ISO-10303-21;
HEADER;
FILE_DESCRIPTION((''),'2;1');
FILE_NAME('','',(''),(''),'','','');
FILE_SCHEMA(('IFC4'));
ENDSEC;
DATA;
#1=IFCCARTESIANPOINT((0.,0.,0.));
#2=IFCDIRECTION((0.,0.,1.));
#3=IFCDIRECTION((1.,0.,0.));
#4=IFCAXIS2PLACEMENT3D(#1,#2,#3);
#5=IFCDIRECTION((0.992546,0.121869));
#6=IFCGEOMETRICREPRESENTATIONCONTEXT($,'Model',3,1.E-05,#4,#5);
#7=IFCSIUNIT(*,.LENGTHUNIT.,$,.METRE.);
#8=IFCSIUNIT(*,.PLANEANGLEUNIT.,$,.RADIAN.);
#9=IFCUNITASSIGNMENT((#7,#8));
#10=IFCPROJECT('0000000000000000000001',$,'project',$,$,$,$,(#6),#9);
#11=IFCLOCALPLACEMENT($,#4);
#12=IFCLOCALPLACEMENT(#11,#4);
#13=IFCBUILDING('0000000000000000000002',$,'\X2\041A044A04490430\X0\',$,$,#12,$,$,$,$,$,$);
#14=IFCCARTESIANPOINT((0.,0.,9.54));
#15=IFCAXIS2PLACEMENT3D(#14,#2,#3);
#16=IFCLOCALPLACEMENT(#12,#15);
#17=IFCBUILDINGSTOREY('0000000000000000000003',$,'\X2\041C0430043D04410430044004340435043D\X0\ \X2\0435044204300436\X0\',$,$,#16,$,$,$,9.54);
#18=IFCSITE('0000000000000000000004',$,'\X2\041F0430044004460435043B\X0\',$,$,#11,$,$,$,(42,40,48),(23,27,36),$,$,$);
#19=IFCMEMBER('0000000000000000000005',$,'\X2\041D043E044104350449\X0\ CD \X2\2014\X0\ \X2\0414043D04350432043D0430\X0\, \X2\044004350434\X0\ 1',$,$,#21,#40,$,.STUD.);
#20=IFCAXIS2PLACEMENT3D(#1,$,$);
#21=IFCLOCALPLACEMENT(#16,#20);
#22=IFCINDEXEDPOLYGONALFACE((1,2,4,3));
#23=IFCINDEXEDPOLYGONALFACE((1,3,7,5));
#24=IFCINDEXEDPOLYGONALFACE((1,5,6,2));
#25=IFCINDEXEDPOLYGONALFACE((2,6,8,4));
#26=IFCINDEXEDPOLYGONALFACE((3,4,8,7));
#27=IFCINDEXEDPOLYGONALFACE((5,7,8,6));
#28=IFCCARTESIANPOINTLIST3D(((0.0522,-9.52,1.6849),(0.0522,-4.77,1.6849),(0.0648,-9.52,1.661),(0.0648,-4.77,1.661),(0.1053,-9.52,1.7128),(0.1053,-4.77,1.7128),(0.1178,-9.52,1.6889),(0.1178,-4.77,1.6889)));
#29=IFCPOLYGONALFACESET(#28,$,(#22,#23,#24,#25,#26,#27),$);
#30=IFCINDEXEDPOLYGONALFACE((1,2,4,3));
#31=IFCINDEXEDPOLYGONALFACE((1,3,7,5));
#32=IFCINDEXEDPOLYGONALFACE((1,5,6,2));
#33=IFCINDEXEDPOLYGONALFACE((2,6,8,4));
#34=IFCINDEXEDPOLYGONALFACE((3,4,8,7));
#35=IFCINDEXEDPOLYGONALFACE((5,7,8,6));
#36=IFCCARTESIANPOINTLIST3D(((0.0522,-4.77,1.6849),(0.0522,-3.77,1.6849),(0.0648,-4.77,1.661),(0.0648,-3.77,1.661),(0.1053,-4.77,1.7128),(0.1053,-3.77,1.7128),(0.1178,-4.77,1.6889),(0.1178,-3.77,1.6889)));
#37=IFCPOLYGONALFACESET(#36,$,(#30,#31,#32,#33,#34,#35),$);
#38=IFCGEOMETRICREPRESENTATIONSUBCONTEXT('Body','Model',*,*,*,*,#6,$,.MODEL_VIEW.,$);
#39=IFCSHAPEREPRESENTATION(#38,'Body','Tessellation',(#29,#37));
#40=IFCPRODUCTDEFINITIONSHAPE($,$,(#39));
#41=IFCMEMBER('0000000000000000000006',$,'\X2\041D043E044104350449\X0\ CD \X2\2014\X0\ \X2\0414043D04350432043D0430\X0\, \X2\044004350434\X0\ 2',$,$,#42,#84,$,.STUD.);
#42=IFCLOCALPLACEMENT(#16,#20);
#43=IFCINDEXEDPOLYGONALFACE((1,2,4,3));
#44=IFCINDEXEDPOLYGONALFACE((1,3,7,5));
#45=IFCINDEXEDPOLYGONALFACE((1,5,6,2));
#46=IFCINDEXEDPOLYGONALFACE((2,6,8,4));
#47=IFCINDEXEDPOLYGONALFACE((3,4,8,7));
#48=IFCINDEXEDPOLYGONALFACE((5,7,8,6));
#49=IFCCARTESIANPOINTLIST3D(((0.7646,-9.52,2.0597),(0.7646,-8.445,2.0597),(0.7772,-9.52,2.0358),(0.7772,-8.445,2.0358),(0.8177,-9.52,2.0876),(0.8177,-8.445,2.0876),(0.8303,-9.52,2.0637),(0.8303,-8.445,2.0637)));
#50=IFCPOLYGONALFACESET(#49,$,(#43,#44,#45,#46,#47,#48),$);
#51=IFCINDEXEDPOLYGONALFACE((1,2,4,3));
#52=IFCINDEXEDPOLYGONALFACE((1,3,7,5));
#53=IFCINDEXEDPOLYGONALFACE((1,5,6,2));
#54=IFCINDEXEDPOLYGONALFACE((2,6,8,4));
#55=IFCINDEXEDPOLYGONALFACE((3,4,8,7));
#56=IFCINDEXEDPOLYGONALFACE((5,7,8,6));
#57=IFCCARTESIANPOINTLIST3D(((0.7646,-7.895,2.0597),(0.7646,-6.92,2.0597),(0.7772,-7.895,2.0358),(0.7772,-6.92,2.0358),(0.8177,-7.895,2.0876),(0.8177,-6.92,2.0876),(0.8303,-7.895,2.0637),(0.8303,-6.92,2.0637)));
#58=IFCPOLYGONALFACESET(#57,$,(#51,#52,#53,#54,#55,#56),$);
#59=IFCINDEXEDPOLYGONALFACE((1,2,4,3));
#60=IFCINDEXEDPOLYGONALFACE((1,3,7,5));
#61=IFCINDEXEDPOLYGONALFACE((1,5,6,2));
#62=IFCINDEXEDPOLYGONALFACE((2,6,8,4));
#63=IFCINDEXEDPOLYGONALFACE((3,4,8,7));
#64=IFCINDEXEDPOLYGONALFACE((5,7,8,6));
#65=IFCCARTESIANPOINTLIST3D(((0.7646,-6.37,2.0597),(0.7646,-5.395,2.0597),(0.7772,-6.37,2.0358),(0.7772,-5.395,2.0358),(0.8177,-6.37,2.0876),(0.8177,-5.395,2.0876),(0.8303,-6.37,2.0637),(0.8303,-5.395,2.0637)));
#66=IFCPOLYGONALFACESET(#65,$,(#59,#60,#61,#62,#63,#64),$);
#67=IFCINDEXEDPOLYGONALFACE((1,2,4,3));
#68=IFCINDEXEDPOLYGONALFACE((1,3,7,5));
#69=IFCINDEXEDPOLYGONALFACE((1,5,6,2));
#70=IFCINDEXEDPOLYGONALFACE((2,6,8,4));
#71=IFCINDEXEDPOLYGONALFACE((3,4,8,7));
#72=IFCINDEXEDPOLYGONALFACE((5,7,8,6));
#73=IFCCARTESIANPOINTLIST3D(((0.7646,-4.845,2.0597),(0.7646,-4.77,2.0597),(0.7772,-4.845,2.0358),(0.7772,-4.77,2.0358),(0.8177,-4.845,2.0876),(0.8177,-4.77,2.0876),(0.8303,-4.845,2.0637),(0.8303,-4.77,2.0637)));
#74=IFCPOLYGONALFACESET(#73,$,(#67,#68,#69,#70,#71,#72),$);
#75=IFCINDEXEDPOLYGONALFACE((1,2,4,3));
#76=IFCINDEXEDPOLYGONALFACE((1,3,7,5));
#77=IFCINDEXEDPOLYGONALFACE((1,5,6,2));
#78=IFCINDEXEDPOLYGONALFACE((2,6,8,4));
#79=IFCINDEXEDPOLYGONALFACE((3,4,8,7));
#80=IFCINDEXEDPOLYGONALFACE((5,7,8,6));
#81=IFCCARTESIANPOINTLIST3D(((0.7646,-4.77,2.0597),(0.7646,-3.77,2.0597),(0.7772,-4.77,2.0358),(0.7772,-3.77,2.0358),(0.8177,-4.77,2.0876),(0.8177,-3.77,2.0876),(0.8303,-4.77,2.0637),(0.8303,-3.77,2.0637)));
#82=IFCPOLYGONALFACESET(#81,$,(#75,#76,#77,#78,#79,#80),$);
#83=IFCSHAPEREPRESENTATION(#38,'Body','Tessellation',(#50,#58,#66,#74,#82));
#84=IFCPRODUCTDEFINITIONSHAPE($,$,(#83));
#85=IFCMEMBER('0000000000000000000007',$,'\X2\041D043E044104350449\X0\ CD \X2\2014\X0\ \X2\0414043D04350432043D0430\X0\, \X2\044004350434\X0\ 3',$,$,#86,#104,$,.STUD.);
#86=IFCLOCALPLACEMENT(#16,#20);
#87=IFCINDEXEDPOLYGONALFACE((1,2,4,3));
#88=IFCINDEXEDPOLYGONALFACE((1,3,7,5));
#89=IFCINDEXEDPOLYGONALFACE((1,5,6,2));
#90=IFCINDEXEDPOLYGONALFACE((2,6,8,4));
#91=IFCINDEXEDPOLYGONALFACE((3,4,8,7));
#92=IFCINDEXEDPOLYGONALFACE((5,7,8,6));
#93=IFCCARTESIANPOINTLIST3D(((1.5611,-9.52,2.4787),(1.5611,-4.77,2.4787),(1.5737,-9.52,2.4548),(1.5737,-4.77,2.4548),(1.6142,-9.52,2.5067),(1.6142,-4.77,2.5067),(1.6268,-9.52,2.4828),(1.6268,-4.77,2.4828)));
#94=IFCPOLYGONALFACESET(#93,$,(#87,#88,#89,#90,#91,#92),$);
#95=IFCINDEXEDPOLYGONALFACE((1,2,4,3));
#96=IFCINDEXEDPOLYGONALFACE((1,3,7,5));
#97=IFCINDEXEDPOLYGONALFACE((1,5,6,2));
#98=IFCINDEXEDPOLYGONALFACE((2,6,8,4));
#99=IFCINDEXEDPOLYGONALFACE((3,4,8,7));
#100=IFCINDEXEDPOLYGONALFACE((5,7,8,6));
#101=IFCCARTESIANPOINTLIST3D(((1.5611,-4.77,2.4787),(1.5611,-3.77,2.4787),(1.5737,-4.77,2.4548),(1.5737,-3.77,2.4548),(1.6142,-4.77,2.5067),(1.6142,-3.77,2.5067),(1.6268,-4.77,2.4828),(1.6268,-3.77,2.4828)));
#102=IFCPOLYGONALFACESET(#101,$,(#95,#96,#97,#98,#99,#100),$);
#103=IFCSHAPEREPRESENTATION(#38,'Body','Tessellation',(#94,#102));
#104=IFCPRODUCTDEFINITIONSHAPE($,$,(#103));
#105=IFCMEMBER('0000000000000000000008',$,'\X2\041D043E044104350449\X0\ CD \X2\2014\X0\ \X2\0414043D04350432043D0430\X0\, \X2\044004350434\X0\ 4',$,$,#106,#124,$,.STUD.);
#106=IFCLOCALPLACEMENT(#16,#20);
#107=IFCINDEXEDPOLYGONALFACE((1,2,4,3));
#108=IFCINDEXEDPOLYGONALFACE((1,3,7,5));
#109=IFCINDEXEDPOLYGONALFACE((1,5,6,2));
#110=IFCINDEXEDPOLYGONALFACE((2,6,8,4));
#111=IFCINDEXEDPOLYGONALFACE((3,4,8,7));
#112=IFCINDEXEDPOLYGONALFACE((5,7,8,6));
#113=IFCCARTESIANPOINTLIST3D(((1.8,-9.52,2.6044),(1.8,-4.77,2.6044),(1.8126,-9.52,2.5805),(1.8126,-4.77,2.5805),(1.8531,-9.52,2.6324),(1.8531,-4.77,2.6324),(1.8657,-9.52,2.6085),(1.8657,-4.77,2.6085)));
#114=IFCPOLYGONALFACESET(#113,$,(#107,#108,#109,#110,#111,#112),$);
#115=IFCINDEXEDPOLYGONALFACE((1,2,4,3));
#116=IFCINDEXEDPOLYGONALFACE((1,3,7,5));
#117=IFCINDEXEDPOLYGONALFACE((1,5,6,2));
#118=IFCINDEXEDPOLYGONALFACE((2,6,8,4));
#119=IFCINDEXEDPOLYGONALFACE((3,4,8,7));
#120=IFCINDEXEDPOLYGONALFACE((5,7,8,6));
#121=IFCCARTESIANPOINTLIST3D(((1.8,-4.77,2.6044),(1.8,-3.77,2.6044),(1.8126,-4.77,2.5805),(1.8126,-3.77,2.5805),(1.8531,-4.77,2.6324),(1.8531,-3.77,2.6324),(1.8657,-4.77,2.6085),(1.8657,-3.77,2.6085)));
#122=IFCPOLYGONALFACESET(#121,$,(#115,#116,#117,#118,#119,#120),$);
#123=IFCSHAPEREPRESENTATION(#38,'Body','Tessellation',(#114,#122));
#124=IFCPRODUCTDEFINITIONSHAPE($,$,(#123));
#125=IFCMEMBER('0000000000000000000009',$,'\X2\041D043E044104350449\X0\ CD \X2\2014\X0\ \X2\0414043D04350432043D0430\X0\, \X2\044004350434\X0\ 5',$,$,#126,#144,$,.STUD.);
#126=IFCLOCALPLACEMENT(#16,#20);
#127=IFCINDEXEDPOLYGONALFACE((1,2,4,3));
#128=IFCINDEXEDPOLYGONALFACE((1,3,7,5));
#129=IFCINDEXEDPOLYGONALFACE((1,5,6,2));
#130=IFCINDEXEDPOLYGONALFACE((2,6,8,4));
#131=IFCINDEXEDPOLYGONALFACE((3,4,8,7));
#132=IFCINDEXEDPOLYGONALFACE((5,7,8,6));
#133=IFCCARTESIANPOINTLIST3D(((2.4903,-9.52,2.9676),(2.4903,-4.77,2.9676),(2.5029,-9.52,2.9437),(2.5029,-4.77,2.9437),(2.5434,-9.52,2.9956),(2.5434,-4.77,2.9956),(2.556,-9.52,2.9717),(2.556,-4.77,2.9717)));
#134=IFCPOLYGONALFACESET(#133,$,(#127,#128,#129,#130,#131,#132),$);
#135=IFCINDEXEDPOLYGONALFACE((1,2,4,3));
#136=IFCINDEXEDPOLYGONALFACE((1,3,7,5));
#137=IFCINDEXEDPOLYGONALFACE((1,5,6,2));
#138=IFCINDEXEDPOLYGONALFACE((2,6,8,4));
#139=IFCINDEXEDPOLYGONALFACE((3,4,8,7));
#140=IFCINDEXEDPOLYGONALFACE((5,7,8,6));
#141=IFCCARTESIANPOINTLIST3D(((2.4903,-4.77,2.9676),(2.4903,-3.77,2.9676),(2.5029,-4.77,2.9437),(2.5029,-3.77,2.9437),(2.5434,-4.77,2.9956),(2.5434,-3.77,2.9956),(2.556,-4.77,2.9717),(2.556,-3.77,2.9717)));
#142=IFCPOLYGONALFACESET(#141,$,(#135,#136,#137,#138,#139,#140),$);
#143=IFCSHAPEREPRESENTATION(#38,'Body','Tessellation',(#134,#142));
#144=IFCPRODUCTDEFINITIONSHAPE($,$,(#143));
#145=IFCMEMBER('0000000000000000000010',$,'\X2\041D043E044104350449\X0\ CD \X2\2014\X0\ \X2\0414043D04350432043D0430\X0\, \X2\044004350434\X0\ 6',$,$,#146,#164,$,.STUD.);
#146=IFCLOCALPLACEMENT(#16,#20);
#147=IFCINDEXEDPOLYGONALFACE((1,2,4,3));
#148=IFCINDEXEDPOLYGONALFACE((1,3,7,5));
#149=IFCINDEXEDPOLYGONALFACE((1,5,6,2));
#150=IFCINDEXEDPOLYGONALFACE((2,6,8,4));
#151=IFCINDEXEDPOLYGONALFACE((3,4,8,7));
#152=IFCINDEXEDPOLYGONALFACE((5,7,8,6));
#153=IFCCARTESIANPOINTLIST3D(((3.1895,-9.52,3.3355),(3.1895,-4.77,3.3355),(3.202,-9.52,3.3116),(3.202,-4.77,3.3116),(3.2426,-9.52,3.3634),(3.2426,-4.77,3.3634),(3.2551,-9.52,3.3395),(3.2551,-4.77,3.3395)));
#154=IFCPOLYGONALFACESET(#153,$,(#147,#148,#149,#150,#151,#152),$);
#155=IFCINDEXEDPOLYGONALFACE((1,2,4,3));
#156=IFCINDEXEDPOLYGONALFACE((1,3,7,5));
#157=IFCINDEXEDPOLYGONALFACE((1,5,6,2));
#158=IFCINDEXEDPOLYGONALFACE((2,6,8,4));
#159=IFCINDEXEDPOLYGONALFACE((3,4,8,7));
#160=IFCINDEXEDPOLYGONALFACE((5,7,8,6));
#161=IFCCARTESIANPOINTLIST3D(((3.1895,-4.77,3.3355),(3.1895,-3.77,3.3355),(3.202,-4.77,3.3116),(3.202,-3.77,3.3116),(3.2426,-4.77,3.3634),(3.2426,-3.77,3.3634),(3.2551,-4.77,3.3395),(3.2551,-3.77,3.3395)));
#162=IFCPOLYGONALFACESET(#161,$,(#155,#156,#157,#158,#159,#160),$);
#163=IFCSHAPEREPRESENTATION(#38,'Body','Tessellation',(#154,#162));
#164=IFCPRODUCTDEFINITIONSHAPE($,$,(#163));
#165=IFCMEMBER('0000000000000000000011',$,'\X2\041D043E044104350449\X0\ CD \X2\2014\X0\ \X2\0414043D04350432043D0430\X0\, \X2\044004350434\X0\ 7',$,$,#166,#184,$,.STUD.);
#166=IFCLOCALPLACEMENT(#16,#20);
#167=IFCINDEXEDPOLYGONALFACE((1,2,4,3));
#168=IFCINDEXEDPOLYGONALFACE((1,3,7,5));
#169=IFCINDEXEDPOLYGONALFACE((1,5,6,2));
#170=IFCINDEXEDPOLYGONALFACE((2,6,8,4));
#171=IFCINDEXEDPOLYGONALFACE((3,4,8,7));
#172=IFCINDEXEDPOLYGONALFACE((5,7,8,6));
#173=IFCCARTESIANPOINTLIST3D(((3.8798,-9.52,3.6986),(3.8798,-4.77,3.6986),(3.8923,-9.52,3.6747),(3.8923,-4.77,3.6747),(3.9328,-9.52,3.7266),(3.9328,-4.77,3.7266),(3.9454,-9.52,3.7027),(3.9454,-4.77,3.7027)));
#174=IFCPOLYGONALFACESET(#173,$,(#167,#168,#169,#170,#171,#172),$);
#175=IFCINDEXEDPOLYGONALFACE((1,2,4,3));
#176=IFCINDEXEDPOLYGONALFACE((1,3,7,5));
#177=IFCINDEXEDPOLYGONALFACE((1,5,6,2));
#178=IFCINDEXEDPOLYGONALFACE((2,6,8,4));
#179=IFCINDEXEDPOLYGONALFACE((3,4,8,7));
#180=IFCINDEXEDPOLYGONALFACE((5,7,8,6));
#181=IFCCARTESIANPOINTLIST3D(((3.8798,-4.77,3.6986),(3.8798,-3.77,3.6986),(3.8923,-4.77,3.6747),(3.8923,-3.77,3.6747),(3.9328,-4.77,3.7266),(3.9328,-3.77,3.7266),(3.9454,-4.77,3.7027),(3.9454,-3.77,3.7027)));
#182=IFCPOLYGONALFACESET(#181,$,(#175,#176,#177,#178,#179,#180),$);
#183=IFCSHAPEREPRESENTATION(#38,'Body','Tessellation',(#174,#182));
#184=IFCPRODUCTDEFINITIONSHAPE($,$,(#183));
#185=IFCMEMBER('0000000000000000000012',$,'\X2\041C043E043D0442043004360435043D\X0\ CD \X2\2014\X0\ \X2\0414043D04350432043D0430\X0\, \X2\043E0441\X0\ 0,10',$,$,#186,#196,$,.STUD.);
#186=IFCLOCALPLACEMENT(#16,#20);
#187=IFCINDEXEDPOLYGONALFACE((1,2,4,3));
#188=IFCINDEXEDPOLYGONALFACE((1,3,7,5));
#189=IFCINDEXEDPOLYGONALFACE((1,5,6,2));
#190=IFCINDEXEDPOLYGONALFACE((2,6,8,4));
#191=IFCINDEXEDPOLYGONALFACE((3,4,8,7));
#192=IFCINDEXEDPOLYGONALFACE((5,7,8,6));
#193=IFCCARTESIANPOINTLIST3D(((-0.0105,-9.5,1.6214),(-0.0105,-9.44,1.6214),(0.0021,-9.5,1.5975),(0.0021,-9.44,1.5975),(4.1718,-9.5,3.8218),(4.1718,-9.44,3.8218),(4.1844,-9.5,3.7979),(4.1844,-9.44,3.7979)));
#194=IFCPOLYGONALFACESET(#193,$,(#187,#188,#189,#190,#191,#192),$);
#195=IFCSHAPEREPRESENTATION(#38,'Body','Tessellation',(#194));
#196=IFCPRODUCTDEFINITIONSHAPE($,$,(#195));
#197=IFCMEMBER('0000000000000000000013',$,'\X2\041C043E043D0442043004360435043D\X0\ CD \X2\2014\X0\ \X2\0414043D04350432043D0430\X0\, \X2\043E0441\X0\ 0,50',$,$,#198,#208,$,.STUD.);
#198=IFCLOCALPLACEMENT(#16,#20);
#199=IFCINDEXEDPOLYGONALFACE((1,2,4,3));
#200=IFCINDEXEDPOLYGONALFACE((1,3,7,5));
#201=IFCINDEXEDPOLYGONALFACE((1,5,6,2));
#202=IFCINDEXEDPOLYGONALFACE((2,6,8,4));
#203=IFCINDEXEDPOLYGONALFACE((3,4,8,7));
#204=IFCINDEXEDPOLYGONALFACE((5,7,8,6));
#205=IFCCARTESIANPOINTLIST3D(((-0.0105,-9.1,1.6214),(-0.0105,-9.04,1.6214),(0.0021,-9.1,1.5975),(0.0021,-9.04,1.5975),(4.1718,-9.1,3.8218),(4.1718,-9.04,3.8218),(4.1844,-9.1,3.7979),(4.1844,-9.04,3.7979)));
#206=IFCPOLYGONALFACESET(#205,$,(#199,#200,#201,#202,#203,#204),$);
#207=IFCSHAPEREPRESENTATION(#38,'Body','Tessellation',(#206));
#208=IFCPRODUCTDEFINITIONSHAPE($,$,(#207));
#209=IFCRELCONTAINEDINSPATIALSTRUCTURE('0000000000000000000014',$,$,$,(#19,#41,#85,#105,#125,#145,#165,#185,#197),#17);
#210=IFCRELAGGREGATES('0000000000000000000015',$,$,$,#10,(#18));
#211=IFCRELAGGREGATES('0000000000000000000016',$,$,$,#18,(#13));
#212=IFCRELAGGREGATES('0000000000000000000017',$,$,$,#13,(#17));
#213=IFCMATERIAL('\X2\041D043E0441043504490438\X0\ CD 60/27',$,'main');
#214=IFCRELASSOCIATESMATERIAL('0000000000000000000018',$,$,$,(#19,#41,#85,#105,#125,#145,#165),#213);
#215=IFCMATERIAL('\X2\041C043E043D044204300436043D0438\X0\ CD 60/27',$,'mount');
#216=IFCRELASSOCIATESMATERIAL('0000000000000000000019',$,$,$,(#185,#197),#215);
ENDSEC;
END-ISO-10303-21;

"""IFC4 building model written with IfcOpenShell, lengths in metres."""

from ifc_helpers import new_model, si_unit, direction, frame, origin_with_axes, place, context, subcontext, project, spatial, polyline, outline, extrude, material, element, save


model = new_model("IFC4")

# Units and contexts
model_context = context("Model", 3, precision=1e-05, world=origin_with_axes(), true_north=direction((0.992546, 0.121869)))
body_context = subcontext(model_context, "Body", "Model", "MODEL_VIEW")
ifc_project = project(units=[si_unit("LENGTHUNIT", "METRE"), si_unit("PLANEANGLEUNIT", "RADIAN")], contexts=[model_context])

# Site, building, storey
site_placement = place(None, origin_with_axes())
site = spatial("IfcSite", under=ifc_project, at=site_placement, Name="Парцел", RefLatitude=(42, 40, 48), RefLongitude=(23, 27, 36))
building_placement = place(site_placement, origin_with_axes())
building = spatial("IfcBuilding", under=site, at=building_placement, Name="Къща")
storey_placement = place(building_placement, frame((0.0, 0.0, 9.54), z_axis=(0.0, 0.0, 1.0), x_axis=(1.0, 0.0, 0.0)))
storey = spatial("IfcBuildingStorey", under=building, at=storey_placement, Name="Мансарден етаж", Elevation=9.54)

# Members
ifc_material_1 = material(Name="Носещи CD 60/27", Category="main")
member_1_placement = place(storey_placement, origin_with_axes())
element("IfcMember", 1, at=member_1_placement, inside=storey, material=ifc_material_1, Name="Носещ CD — Дневна, ред 1", PredefinedType="STUD", context=body_context, shape_type="SweptSolid", body=[
    extrude(outline(polyline([(0.0648, -1.661), (0.1178, -1.6889), (0.1053, -1.7128), (0.0522, -1.6849), (0.0648, -1.661)])), frame((0.0, -9.52, 0.0), z_axis=(0.0, 1.0, 0.0), x_axis=(1.0, 0.0, 0.0)), (0.0, 0.0, 1.0), 4.75),
    extrude(outline(polyline([(0.0648, -1.661), (0.1178, -1.6889), (0.1053, -1.7128), (0.0522, -1.6849), (0.0648, -1.661)])), frame((0.0, -4.77, 0.0), z_axis=(0.0, 1.0, 0.0), x_axis=(1.0, 0.0, 0.0)), (0.0, 0.0, 1.0), 1.0),
])
member_2_placement = place(storey_placement, origin_with_axes())
element("IfcMember", 2, at=member_2_placement, inside=storey, material=ifc_material_1, Name="Носещ CD — Дневна, ред 2", PredefinedType="STUD", context=body_context, shape_type="SweptSolid", body=[
    extrude(outline(polyline([(0.7772, -2.0358), (0.8303, -2.0637), (0.8177, -2.0876), (0.7646, -2.0597), (0.7772, -2.0358)])), frame((0.0, -9.52, 0.0), z_axis=(0.0, 1.0, 0.0), x_axis=(1.0, 0.0, 0.0)), (0.0, 0.0, 1.0), 1.075),
    extrude(outline(polyline([(0.7772, -2.0358), (0.8303, -2.0637), (0.8177, -2.0876), (0.7646, -2.0597), (0.7772, -2.0358)])), frame((0.0, -7.895, 0.0), z_axis=(0.0, 1.0, 0.0), x_axis=(1.0, 0.0, 0.0)), (0.0, 0.0, 1.0), 0.975),
    extrude(outline(polyline([(0.7772, -2.0358), (0.8303, -2.0637), (0.8177, -2.0876), (0.7646, -2.0597), (0.7772, -2.0358)])), frame((0.0, -6.37, 0.0), z_axis=(0.0, 1.0, 0.0), x_axis=(1.0, 0.0, 0.0)), (0.0, 0.0, 1.0), 0.975),
    extrude(outline(polyline([(0.7772, -2.0358), (0.8303, -2.0637), (0.8177, -2.0876), (0.7646, -2.0597), (0.7772, -2.0358)])), frame((0.0, -4.845, 0.0), z_axis=(0.0, 1.0, 0.0), x_axis=(1.0, 0.0, 0.0)), (0.0, 0.0, 1.0), 0.075),
    extrude(outline(polyline([(0.7772, -2.0358), (0.8303, -2.0637), (0.8177, -2.0876), (0.7646, -2.0597), (0.7772, -2.0358)])), frame((0.0, -4.77, 0.0), z_axis=(0.0, 1.0, 0.0), x_axis=(1.0, 0.0, 0.0)), (0.0, 0.0, 1.0), 1.0),
])
member_3_placement = place(storey_placement, origin_with_axes())
element("IfcMember", 3, at=member_3_placement, inside=storey, material=ifc_material_1, Name="Носещ CD — Дневна, ред 3", PredefinedType="STUD", context=body_context, shape_type="SweptSolid", body=[
    extrude(outline(polyline([(1.5737, -2.4548), (1.6268, -2.4828), (1.6142, -2.5067), (1.5611, -2.4787), (1.5737, -2.4548)])), frame((0.0, -9.52, 0.0), z_axis=(0.0, 1.0, 0.0), x_axis=(1.0, 0.0, 0.0)), (0.0, 0.0, 1.0), 4.75),
    extrude(outline(polyline([(1.5737, -2.4548), (1.6268, -2.4828), (1.6142, -2.5067), (1.5611, -2.4787), (1.5737, -2.4548)])), frame((0.0, -4.77, 0.0), z_axis=(0.0, 1.0, 0.0), x_axis=(1.0, 0.0, 0.0)), (0.0, 0.0, 1.0), 1.0),
])
member_4_placement = place(storey_placement, origin_with_axes())
element("IfcMember", 4, at=member_4_placement, inside=storey, material=ifc_material_1, Name="Носещ CD — Дневна, ред 4", PredefinedType="STUD", context=body_context, shape_type="SweptSolid", body=[
    extrude(outline(polyline([(1.8126, -2.5805), (1.8657, -2.6085), (1.8531, -2.6324), (1.8, -2.6044), (1.8126, -2.5805)])), frame((0.0, -9.52, 0.0), z_axis=(0.0, 1.0, 0.0), x_axis=(1.0, 0.0, 0.0)), (0.0, 0.0, 1.0), 4.75),
    extrude(outline(polyline([(1.8126, -2.5805), (1.8657, -2.6085), (1.8531, -2.6324), (1.8, -2.6044), (1.8126, -2.5805)])), frame((0.0, -4.77, 0.0), z_axis=(0.0, 1.0, 0.0), x_axis=(1.0, 0.0, 0.0)), (0.0, 0.0, 1.0), 1.0),
])
member_5_placement = place(storey_placement, origin_with_axes())
element("IfcMember", 5, at=member_5_placement, inside=storey, material=ifc_material_1, Name="Носещ CD — Дневна, ред 5", PredefinedType="STUD", context=body_context, shape_type="SweptSolid", body=[
    extrude(outline(polyline([(2.5029, -2.9437), (2.556, -2.9717), (2.5434, -2.9956), (2.4903, -2.9676), (2.5029, -2.9437)])), frame((0.0, -9.52, 0.0), z_axis=(0.0, 1.0, 0.0), x_axis=(1.0, 0.0, 0.0)), (0.0, 0.0, 1.0), 4.75),
    extrude(outline(polyline([(2.5029, -2.9437), (2.556, -2.9717), (2.5434, -2.9956), (2.4903, -2.9676), (2.5029, -2.9437)])), frame((0.0, -4.77, 0.0), z_axis=(0.0, 1.0, 0.0), x_axis=(1.0, 0.0, 0.0)), (0.0, 0.0, 1.0), 1.0),
])
member_6_placement = place(storey_placement, origin_with_axes())
element("IfcMember", 6, at=member_6_placement, inside=storey, material=ifc_material_1, Name="Носещ CD — Дневна, ред 6", PredefinedType="STUD", context=body_context, shape_type="SweptSolid", body=[
    extrude(outline(polyline([(3.202, -3.3116), (3.2551, -3.3395), (3.2426, -3.3634), (3.1895, -3.3355), (3.202, -3.3116)])), frame((0.0, -9.52, 0.0), z_axis=(0.0, 1.0, 0.0), x_axis=(1.0, 0.0, 0.0)), (0.0, 0.0, 1.0), 4.75),
    extrude(outline(polyline([(3.202, -3.3116), (3.2551, -3.3395), (3.2426, -3.3634), (3.1895, -3.3355), (3.202, -3.3116)])), frame((0.0, -4.77, 0.0), z_axis=(0.0, 1.0, 0.0), x_axis=(1.0, 0.0, 0.0)), (0.0, 0.0, 1.0), 1.0),
])
member_7_placement = place(storey_placement, origin_with_axes())
element("IfcMember", 7, at=member_7_placement, inside=storey, material=ifc_material_1, Name="Носещ CD — Дневна, ред 7", PredefinedType="STUD", context=body_context, shape_type="SweptSolid", body=[
    extrude(outline(polyline([(3.8923, -3.6747), (3.9454, -3.7027), (3.9329, -3.7266), (3.8798, -3.6986), (3.8923, -3.6747)])), frame((0.0, -9.52, 0.0), z_axis=(0.0, 1.0, 0.0), x_axis=(1.0, 0.0, 0.0)), (0.0, 0.0, 1.0), 4.75),
    extrude(outline(polyline([(3.8923, -3.6747), (3.9454, -3.7027), (3.9329, -3.7266), (3.8798, -3.6986), (3.8923, -3.6747)])), frame((0.0, -4.77, 0.0), z_axis=(0.0, 1.0, 0.0), x_axis=(1.0, 0.0, 0.0)), (0.0, 0.0, 1.0), 1.0),
])
ifc_material_2 = material(Name="Монтажни CD 60/27", Category="mount")
member_8_placement = place(storey_placement, origin_with_axes())
element("IfcMember", 8, at=member_8_placement, inside=storey, material=ifc_material_2, Name="Монтажен CD — Дневна, ос 0,10", PredefinedType="STUD", context=body_context, shape_type="SweptSolid", body=[
    extrude(outline(polyline([(0.0021, -1.5975), (4.1844, -3.7979), (4.1718, -3.8218), (-0.0105, -1.6214), (0.0021, -1.5975)])), frame((0.0, -9.5, 0.0), z_axis=(0.0, 1.0, 0.0), x_axis=(1.0, 0.0, 0.0)), (0.0, 0.0, 1.0), 0.06),
])
member_9_placement = place(storey_placement, origin_with_axes())
element("IfcMember", 9, at=member_9_placement, inside=storey, material=ifc_material_2, Name="Монтажен CD — Дневна, ос 0,50", PredefinedType="STUD", context=body_context, shape_type="SweptSolid", body=[
    extrude(outline(polyline([(0.0021, -1.5975), (4.1844, -3.7979), (4.1718, -3.8218), (-0.0105, -1.6214), (0.0021, -1.5975)])), frame((0.0, -9.1, 0.0), z_axis=(0.0, 1.0, 0.0), x_axis=(1.0, 0.0, 0.0)), (0.0, 0.0, 1.0), 0.06),
])

save(model, "model.ifc")
